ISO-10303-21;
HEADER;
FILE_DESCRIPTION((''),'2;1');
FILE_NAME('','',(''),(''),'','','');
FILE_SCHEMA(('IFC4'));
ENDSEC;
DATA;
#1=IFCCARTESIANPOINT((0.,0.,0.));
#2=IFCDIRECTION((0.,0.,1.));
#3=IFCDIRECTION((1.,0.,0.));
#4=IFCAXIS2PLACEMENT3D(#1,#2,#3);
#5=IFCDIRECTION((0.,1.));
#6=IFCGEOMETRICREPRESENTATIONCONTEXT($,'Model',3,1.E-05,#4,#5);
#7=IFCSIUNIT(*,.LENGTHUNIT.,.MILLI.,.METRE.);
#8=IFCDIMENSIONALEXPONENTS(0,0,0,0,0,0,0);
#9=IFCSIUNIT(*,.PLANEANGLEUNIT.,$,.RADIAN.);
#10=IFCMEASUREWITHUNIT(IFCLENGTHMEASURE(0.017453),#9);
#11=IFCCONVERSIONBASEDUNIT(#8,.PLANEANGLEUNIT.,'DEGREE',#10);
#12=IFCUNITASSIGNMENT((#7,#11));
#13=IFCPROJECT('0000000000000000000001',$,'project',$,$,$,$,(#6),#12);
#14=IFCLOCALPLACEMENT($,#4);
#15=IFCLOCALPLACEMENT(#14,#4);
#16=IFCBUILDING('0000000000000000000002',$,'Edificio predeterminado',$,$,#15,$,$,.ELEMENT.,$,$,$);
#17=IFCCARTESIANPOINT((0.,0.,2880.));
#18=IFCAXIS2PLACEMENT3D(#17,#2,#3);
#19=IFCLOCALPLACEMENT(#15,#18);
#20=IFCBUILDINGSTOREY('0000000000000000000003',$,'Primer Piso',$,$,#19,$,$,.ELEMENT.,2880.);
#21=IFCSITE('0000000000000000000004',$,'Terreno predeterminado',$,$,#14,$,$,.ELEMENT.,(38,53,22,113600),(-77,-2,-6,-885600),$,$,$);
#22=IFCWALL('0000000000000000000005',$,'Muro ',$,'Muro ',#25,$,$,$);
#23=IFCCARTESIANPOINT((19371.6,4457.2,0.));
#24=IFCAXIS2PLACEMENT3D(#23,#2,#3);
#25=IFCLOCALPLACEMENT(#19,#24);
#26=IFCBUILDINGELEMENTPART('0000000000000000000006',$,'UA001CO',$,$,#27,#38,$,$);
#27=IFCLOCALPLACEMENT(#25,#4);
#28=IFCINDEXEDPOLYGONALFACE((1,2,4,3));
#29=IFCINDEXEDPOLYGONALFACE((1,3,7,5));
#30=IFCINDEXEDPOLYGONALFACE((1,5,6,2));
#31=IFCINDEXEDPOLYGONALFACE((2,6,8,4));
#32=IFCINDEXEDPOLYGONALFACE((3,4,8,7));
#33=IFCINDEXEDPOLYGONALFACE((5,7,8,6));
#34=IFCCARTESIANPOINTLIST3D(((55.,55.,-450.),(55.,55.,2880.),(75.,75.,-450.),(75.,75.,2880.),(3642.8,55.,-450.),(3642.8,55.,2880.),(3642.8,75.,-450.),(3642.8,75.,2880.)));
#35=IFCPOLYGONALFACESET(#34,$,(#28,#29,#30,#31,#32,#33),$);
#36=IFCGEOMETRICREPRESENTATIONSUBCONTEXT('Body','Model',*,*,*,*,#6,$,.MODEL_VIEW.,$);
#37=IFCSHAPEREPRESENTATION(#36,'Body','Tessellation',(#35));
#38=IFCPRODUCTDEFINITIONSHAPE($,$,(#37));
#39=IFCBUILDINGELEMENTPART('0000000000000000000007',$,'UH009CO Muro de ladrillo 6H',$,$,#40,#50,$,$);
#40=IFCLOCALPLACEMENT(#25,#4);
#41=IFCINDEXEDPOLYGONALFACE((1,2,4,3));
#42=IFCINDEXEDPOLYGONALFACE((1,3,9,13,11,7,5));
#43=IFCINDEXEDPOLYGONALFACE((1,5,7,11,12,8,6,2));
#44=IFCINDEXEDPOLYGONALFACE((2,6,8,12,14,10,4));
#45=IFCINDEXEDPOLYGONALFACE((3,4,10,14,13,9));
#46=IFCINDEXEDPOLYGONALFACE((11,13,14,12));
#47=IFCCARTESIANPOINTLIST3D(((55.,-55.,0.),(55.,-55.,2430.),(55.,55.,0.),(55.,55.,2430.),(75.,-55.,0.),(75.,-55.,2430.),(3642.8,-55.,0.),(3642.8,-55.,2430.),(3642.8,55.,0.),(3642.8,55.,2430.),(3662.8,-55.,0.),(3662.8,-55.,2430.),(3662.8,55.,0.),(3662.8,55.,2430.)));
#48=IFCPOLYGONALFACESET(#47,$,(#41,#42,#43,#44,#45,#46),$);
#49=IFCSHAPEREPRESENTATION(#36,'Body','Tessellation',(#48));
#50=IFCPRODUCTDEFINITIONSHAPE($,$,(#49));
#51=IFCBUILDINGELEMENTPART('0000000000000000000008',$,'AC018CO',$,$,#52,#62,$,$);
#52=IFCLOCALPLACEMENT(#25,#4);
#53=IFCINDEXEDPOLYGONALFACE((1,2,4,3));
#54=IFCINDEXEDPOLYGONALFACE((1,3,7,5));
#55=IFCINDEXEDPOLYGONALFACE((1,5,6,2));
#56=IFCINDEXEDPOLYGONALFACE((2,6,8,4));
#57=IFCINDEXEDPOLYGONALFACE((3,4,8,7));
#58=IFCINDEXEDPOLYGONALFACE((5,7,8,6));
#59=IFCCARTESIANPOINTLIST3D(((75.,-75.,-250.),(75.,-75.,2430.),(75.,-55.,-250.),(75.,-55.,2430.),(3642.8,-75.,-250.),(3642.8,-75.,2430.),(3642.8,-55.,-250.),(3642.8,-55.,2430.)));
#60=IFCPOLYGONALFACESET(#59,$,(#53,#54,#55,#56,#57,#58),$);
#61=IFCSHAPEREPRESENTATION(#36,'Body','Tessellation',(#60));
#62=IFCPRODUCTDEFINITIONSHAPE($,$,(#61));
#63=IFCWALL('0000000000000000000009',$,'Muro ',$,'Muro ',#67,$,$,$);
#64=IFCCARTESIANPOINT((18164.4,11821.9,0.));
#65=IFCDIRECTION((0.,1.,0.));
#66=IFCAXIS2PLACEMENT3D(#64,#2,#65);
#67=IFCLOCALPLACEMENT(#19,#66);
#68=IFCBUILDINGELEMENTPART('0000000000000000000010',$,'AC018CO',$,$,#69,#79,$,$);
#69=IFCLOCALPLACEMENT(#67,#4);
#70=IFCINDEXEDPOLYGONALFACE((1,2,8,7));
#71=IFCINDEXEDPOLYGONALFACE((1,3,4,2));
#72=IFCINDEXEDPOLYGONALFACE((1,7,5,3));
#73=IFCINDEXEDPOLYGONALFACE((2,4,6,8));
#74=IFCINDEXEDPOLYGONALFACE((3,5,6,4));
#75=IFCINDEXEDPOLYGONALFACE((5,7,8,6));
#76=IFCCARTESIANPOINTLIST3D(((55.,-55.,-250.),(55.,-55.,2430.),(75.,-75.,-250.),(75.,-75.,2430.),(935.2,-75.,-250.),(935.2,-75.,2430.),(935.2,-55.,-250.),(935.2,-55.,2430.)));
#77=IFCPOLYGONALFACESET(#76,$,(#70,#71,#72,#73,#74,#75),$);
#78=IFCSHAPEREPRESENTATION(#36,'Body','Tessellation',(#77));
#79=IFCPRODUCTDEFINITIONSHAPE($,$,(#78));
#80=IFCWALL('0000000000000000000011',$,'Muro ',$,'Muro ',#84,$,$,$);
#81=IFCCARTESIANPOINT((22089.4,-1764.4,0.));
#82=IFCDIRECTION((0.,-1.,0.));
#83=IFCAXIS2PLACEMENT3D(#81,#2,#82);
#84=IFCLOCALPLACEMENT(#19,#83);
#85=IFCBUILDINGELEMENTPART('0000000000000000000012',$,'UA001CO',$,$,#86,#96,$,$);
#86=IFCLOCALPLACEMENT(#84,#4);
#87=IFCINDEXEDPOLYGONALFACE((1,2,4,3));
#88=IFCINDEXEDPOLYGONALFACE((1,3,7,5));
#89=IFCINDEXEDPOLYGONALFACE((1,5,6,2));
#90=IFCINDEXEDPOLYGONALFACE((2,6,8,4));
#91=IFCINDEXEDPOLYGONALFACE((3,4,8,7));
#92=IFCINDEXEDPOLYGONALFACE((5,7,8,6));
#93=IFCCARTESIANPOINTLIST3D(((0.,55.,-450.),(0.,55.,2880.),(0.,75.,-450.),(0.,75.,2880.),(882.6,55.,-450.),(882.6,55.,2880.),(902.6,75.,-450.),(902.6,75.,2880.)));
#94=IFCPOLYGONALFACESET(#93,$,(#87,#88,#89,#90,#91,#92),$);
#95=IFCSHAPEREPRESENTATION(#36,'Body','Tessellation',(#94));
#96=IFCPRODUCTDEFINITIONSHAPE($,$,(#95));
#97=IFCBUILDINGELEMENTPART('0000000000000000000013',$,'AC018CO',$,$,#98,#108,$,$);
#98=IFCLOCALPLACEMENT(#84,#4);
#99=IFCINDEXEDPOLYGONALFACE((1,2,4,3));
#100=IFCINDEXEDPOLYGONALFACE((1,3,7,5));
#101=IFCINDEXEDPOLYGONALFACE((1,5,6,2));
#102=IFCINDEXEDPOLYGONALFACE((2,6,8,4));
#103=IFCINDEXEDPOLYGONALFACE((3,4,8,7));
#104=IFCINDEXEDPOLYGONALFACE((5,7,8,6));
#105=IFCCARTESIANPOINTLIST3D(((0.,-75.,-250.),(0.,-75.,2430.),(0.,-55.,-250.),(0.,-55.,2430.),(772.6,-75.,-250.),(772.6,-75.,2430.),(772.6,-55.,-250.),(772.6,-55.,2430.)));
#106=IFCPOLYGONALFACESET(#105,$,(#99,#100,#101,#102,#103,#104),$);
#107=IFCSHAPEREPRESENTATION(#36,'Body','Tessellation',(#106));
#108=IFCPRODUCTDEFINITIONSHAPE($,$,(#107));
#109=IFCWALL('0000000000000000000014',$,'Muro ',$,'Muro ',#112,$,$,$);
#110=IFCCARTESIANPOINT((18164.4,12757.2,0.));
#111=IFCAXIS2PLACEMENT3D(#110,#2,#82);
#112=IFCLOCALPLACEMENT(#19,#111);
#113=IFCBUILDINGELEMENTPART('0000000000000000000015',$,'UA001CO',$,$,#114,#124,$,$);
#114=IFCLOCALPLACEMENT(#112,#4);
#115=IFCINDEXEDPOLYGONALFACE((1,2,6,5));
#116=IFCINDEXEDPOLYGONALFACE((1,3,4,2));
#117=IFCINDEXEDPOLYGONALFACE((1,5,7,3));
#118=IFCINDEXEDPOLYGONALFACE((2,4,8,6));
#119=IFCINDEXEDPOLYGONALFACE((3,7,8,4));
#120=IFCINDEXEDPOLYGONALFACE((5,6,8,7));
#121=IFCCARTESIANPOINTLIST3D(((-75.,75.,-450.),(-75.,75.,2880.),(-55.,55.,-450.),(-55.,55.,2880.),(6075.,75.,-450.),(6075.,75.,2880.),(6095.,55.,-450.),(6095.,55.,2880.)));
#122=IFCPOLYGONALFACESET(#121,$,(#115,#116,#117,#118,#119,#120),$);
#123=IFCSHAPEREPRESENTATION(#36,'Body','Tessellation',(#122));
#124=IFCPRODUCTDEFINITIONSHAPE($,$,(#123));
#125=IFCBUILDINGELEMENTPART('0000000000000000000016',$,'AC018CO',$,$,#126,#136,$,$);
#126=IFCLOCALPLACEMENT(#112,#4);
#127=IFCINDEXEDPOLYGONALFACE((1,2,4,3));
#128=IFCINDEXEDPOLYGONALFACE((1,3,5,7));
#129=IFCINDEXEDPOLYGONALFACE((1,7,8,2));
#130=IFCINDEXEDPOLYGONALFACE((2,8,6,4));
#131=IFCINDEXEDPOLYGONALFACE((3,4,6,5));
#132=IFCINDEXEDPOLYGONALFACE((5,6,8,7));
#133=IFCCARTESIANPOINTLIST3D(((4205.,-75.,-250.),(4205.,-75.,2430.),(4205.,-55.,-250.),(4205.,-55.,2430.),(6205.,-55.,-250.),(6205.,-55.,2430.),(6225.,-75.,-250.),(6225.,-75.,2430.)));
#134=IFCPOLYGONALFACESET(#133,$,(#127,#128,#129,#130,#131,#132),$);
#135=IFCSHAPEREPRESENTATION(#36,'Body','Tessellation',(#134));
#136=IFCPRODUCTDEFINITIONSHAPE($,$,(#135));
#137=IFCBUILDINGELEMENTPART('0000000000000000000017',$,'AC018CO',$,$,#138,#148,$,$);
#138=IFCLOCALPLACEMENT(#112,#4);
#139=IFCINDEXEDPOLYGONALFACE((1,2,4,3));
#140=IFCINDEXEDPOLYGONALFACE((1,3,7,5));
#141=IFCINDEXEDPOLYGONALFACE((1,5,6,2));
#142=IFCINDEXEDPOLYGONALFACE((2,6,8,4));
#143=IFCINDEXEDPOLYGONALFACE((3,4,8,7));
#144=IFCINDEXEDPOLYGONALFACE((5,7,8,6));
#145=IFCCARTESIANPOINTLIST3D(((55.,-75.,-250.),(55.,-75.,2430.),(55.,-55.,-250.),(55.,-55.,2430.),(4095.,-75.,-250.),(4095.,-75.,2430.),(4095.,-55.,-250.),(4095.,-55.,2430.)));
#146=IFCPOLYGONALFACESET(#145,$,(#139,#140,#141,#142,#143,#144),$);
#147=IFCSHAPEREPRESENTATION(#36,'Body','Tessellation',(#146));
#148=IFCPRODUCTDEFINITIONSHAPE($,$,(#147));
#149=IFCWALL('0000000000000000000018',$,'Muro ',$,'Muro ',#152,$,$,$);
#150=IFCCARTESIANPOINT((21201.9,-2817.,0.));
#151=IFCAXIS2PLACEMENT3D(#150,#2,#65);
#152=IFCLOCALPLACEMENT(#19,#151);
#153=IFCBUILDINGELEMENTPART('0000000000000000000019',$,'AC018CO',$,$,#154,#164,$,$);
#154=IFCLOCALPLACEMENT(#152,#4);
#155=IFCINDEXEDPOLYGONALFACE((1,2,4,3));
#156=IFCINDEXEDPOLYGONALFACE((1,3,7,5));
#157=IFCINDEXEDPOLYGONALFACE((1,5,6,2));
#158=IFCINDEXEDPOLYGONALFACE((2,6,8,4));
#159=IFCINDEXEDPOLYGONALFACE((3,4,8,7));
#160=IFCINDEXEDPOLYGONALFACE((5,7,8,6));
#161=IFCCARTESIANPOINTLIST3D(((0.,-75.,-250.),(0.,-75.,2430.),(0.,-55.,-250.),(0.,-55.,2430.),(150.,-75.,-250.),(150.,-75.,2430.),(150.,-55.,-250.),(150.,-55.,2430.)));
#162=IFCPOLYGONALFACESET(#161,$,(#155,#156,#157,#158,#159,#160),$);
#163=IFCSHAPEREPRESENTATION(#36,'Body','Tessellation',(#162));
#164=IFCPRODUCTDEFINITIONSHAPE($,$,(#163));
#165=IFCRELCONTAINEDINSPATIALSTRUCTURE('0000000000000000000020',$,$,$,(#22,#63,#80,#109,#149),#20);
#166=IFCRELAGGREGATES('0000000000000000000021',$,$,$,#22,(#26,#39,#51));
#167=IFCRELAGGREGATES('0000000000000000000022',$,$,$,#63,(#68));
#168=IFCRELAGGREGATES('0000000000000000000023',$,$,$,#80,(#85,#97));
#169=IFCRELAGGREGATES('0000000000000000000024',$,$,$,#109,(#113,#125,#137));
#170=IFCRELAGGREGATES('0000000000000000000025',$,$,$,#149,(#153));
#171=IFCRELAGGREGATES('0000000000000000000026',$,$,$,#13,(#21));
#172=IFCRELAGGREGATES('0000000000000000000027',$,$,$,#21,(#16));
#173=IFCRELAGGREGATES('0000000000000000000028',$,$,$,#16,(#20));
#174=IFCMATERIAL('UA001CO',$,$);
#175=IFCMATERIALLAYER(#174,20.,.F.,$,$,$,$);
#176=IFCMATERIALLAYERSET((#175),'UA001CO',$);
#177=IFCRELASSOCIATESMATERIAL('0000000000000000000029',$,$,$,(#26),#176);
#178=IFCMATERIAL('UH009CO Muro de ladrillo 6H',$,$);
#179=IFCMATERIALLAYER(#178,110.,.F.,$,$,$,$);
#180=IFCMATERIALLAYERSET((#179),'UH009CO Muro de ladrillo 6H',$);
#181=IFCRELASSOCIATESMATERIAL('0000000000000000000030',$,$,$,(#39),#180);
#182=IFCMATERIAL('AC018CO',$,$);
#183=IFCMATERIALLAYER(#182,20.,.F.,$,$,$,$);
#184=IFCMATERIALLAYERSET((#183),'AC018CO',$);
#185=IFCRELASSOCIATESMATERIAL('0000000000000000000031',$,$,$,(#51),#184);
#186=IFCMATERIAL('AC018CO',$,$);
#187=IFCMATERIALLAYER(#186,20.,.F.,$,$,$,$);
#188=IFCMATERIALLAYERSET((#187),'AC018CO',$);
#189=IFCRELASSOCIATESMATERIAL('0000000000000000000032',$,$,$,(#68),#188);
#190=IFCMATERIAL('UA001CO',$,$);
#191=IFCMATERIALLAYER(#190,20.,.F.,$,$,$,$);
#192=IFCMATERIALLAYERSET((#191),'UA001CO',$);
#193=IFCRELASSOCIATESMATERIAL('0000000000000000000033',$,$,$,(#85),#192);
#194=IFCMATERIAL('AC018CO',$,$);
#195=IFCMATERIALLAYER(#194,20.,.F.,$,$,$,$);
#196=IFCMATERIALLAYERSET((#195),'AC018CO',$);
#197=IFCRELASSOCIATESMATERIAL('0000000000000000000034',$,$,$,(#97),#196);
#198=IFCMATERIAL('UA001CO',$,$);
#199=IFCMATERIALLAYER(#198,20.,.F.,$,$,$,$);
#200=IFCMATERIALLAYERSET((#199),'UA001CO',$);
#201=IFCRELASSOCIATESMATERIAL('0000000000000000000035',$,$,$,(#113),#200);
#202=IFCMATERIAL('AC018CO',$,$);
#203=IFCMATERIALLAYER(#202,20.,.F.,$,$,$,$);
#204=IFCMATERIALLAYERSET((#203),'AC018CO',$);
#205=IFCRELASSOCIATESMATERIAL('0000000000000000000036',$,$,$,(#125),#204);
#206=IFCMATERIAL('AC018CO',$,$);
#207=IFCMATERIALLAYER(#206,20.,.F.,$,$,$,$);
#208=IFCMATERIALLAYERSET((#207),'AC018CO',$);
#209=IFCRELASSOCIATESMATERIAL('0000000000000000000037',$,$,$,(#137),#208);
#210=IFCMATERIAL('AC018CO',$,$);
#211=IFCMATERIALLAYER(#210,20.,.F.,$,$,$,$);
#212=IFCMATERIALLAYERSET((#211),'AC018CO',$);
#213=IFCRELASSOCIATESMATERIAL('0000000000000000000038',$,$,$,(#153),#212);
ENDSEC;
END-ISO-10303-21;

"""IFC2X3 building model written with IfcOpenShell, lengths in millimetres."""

from ifc_helpers import new_model, entity, si_unit, converted_unit, direction, frame, origin_with_axes, place, context, subcontext, project, spatial, polyline, outline, extrude, clip, bounded_halfspace, material, layer, layer_set, layer_usage, element, aggregate, save


model = new_model("IFC2X3")

# Units and contexts
model_context = context("Model", 3, precision=1e-05, world=origin_with_axes(), true_north=direction((0.0, 1.0)))
body_context = subcontext(model_context, "Body", "Model", "MODEL_VIEW")
ifc_project = project(units=[si_unit("LENGTHUNIT", "METRE", prefix="MILLI"), converted_unit("PLANEANGLEUNIT", "DEGREE", entity("IfcLengthMeasure", 0.017453), si_unit("PLANEANGLEUNIT", "RADIAN"), dimensions=[0, 0, 0, 0, 0, 0, 0])], contexts=[model_context])

# Site, building, storey
site_placement = place(None, origin_with_axes())
site = spatial("IfcSite", under=ifc_project, at=site_placement, Name="Terreno predeterminado", CompositionType="ELEMENT", RefLatitude=(38, 53, 22, 113600), RefLongitude=(-77, -2, -6, -885600))
building_placement = place(site_placement, origin_with_axes())
building = spatial("IfcBuilding", under=site, at=building_placement, Name="Edificio predeterminado", CompositionType="ELEMENT")
storey_placement = place(building_placement, frame((0.0, 0.0, 2880.0), z_axis=(0.0, 0.0, 1.0), x_axis=(1.0, 0.0, 0.0)))
storey = spatial("IfcBuildingStorey", under=building, at=storey_placement, Name="Primer Piso", CompositionType="ELEMENT", Elevation=2880.0)

# Walls, building element parts
wall_1_placement = place(storey_placement, frame((19371.6, 4457.2, 0.0), z_axis=(0.0, 0.0, 1.0), x_axis=(1.0, 0.0, 0.0)))
wall_1 = element("IfcWall", 1, at=wall_1_placement, inside=storey, Name="Muro ", ObjectType="Muro ")
ifc_material_1 = material(Name="UA001CO")
ifc_layer_1 = layer(ifc_material_1, 20.0, ventilated=False)
ifc_layer_set_1 = layer_set([ifc_layer_1], Name="UA001CO")
ifc_layer_usage_1 = layer_usage(ifc_layer_set_1, "AXIS2", "NEGATIVE", -75.0)
building_element_part_1_placement = place(wall_1_placement, origin_with_axes())
building_element_part_1 = element("IfcBuildingElementPart", 2, at=building_element_part_1_placement, material=ifc_layer_usage_1, Name="UA001CO", context=body_context, shape_type="SweptSolid", body=[
    extrude(outline(polyline([(3642.8, 75.0), (3642.8, 55.0), (55.0, 55.0), (75.0, 75.0), (3642.8, 75.0)])), frame((0.0, 0.0, -450.0), z_axis=(0.0, 0.0, 1.0), x_axis=(1.0, 0.0, 0.0)), (0.0, 0.0, 1.0), 3330.0),
])
ifc_material_2 = material(Name="UH009CO Muro de ladrillo 6H")
ifc_layer_2 = layer(ifc_material_2, 110.0, ventilated=False)
ifc_layer_set_2 = layer_set([ifc_layer_2], Name="UH009CO Muro de ladrillo 6H")
ifc_layer_usage_2 = layer_usage(ifc_layer_set_2, "AXIS2", "NEGATIVE", -55.0)
building_element_part_2_placement = place(wall_1_placement, origin_with_axes())
building_element_part_2 = element("IfcBuildingElementPart", 3, at=building_element_part_2_placement, material=ifc_layer_usage_2, Name="UH009CO Muro de ladrillo 6H", context=body_context, shape_type="SweptSolid", body=[
    extrude(outline(polyline([(3662.8, 55.0), (3662.8, -55.0), (3642.8, -55.0), (75.0, -55.0), (55.0, -55.0), (55.0, 55.0), (3642.8, 55.0), (3662.8, 55.0)])), origin_with_axes(), (0.0, 0.0, 1.0), 2430.0),
])
ifc_material_3 = material(Name="AC018CO")
ifc_layer_3 = layer(ifc_material_3, 20.0, ventilated=False)
ifc_layer_set_3 = layer_set([ifc_layer_3], Name="AC018CO")
ifc_layer_usage_3 = layer_usage(ifc_layer_set_3, "AXIS2", "NEGATIVE", 55.0)
building_element_part_3_placement = place(wall_1_placement, origin_with_axes())
building_element_part_3 = element("IfcBuildingElementPart", 4, at=building_element_part_3_placement, material=ifc_layer_usage_3, Name="AC018CO", context=body_context, shape_type="SweptSolid", body=[
    extrude(outline(polyline([(3642.8, -55.0), (3642.8, -75.0), (75.0, -75.0), (75.0, -55.0), (3642.8, -55.0)])), frame((0.0, 0.0, -250.0), z_axis=(0.0, 0.0, 1.0), x_axis=(1.0, 0.0, 0.0)), (0.0, 0.0, 1.0), 2680.0),
])
aggregate(wall_1, [building_element_part_1, building_element_part_2, building_element_part_3])
wall_2_placement = place(storey_placement, frame((18164.4, 11821.9, 0.0), z_axis=(0.0, 0.0, 1.0), x_axis=(0.0, 1.0, 0.0)))
wall_2 = element("IfcWall", 5, at=wall_2_placement, inside=storey, Name="Muro ", ObjectType="Muro ")
ifc_material_4 = material(Name="AC018CO")
ifc_layer_4 = layer(ifc_material_4, 20.0, ventilated=False)
ifc_layer_set_4 = layer_set([ifc_layer_4], Name="AC018CO")
ifc_layer_usage_4 = layer_usage(ifc_layer_set_4, "AXIS2", "NEGATIVE", 55.0)
building_element_part_4_placement = place(wall_2_placement, origin_with_axes())
building_element_part_4 = element("IfcBuildingElementPart", 6, at=building_element_part_4_placement, material=ifc_layer_usage_4, Name="AC018CO", context=body_context, shape_type="SweptSolid", body=[
    extrude(outline(polyline([(935.2, -55.0), (935.2, -75.0), (75.0, -75.0), (55.0, -55.0), (935.2, -55.0)])), frame((0.0, 0.0, -250.0), z_axis=(0.0, 0.0, 1.0), x_axis=(1.0, 0.0, 0.0)), (0.0, 0.0, 1.0), 2680.0),
])
aggregate(wall_2, [building_element_part_4])
wall_3_placement = place(storey_placement, frame((22089.4, -1764.4, 0.0), z_axis=(0.0, 0.0, 1.0), x_axis=(0.0, -1.0, 0.0)))
wall_3 = element("IfcWall", 7, at=wall_3_placement, inside=storey, Name="Muro ", ObjectType="Muro ")
ifc_material_5 = material(Name="UA001CO")
ifc_layer_5 = layer(ifc_material_5, 20.0, ventilated=False)
ifc_layer_set_5 = layer_set([ifc_layer_5], Name="UA001CO")
ifc_layer_usage_5 = layer_usage(ifc_layer_set_5, "AXIS2", "NEGATIVE", -75.0)
building_element_part_5_placement = place(wall_3_placement, origin_with_axes())
building_element_part_5 = element("IfcBuildingElementPart", 8, at=building_element_part_5_placement, material=ifc_layer_usage_5, Name="UA001CO", context=body_context, shape_type="SweptSolid", body=[
    extrude(outline(polyline([(902.6, 75.0), (882.6, 55.0), (0.0, 55.0), (0.0, 75.0), (902.6, 75.0)])), frame((0.0, 0.0, -450.0), z_axis=(0.0, 0.0, 1.0), x_axis=(1.0, 0.0, 0.0)), (0.0, 0.0, 1.0), 3330.0),
])
ifc_material_6 = material(Name="AC018CO")
ifc_layer_6 = layer(ifc_material_6, 20.0, ventilated=False)
ifc_layer_set_6 = layer_set([ifc_layer_6], Name="AC018CO")
ifc_layer_usage_6 = layer_usage(ifc_layer_set_6, "AXIS2", "NEGATIVE", 55.0)
building_element_part_6_placement = place(wall_3_placement, origin_with_axes())
building_element_part_6 = element("IfcBuildingElementPart", 9, at=building_element_part_6_placement, material=ifc_layer_usage_6, Name="AC018CO", context=body_context, shape_type="SweptSolid", body=[
    extrude(outline(polyline([(772.6, -55.0), (772.6, -75.0), (0.0, -75.0), (0.0, -55.0), (772.6, -55.0)])), frame((0.0, 0.0, -250.0), z_axis=(0.0, 0.0, 1.0), x_axis=(1.0, 0.0, 0.0)), (0.0, 0.0, 1.0), 2680.0),
])
aggregate(wall_3, [building_element_part_5, building_element_part_6])
wall_4_placement = place(storey_placement, frame((18164.4, 12757.2, 0.0), z_axis=(0.0, 0.0, 1.0), x_axis=(0.0, -1.0, 0.0)))
wall_4 = element("IfcWall", 10, at=wall_4_placement, inside=storey, Name="Muro ", ObjectType="Muro ")
ifc_material_7 = material(Name="UA001CO")
ifc_layer_7 = layer(ifc_material_7, 20.0, ventilated=False)
ifc_layer_set_7 = layer_set([ifc_layer_7], Name="UA001CO")
ifc_layer_usage_7 = layer_usage(ifc_layer_set_7, "AXIS2", "NEGATIVE", -75.0)
building_element_part_7_placement = place(wall_4_placement, origin_with_axes())
building_element_part_7 = element("IfcBuildingElementPart", 11, at=building_element_part_7_placement, material=ifc_layer_usage_7, Name="UA001CO", context=body_context, shape_type="SweptSolid", body=[
    extrude(outline(polyline([(6075.0, 75.0), (6095.0, 55.0), (-55.0, 55.0), (-75.0, 75.0), (6075.0, 75.0)])), frame((0.0, 0.0, -450.0), z_axis=(0.0, 0.0, 1.0), x_axis=(1.0, 0.0, 0.0)), (0.0, 0.0, 1.0), 3330.0),
])
ifc_material_8 = material(Name="AC018CO")
ifc_layer_8 = layer(ifc_material_8, 20.0, ventilated=False)
ifc_layer_set_8 = layer_set([ifc_layer_8], Name="AC018CO")
ifc_layer_usage_8 = layer_usage(ifc_layer_set_8, "AXIS2", "NEGATIVE", 55.0)
building_element_part_8_placement = place(wall_4_placement, origin_with_axes())
building_element_part_8 = element("IfcBuildingElementPart", 12, at=building_element_part_8_placement, material=ifc_layer_usage_8, Name="AC018CO", context=body_context, shape_type="SweptSolid", body=[
    extrude(outline(polyline([(6205.0, -55.0), (6225.0, -75.0), (4205.0, -75.0), (4205.0, -55.0), (6205.0, -55.0)])), frame((0.0, 0.0, -250.0), z_axis=(0.0, 0.0, 1.0), x_axis=(1.0, 0.0, 0.0)), (0.0, 0.0, 1.0), 2680.0),
])
ifc_material_9 = material(Name="AC018CO")
ifc_layer_9 = layer(ifc_material_9, 20.0, ventilated=False)
ifc_layer_set_9 = layer_set([ifc_layer_9], Name="AC018CO")
ifc_layer_usage_9 = layer_usage(ifc_layer_set_9, "AXIS2", "NEGATIVE", 55.0)
building_element_part_9_placement = place(wall_4_placement, origin_with_axes())
building_element_part_9 = element("IfcBuildingElementPart", 13, at=building_element_part_9_placement, material=ifc_layer_usage_9, Name="AC018CO", context=body_context, shape_type="SweptSolid", body=[
    extrude(outline(polyline([(4095.0, -55.0), (4095.0, -75.0), (55.0, -75.0), (55.0, -55.0), (4095.0, -55.0)])), frame((0.0, 0.0, -250.0), z_axis=(0.0, 0.0, 1.0), x_axis=(1.0, 0.0, 0.0)), (0.0, 0.0, 1.0), 2680.0),
])
aggregate(wall_4, [building_element_part_7, building_element_part_8, building_element_part_9])
wall_5_placement = place(storey_placement, frame((21201.9, -2817.0, 0.0), z_axis=(0.0, 0.0, 1.0), x_axis=(0.0, 1.0, 0.0)))
wall_5 = element("IfcWall", 14, at=wall_5_placement, inside=storey, Name="Muro ", ObjectType="Muro ")
ifc_material_10 = material(Name="AC018CO")
ifc_layer_10 = layer(ifc_material_10, 20.0, ventilated=False)
ifc_layer_set_10 = layer_set([ifc_layer_10], Name="AC018CO")
ifc_layer_usage_10 = layer_usage(ifc_layer_set_10, "AXIS2", "NEGATIVE", 55.0)
building_element_part_10_placement = place(wall_5_placement, origin_with_axes())
building_element_part_10 = element("IfcBuildingElementPart", 15, at=building_element_part_10_placement, material=ifc_layer_usage_10, Name="AC018CO", context=body_context, shape_type="Clipping", body=[
    clip(clip(extrude(outline(polyline([(150.0, -55.0), (150.0, -75.0), (0.0, -75.0), (0.0, -55.0), (150.0, -55.0)])), frame((0.0, 0.0, -250.0), z_axis=(0.0, 0.0, 1.0), x_axis=(1.0, 0.0, 0.0)), (0.0, 0.0, 1.0), 2680.0), bounded_halfspace(frame((0.0, 0.0, -250.0), z_axis=(0.0, 0.0, 1.0), x_axis=(1.0, 0.0, 0.0)), True, origin_with_axes(), polyline([(-150.0, -150.0), (375.0, -150.0), (375.0, 150.0), (-150.0, 150.0), (-150.0, -150.0)]))), bounded_halfspace(frame((0.0, 0.0, 2430.0), z_axis=(0.0, 0.0, 1.0), x_axis=(1.0, 0.0, 0.0)), False, origin_with_axes(), polyline([(-150.0, -150.0), (375.0, -150.0), (375.0, 150.0), (-150.0, 150.0), (-150.0, -150.0)]))),
])
aggregate(wall_5, [building_element_part_10])

save(model, "model.ifc")
